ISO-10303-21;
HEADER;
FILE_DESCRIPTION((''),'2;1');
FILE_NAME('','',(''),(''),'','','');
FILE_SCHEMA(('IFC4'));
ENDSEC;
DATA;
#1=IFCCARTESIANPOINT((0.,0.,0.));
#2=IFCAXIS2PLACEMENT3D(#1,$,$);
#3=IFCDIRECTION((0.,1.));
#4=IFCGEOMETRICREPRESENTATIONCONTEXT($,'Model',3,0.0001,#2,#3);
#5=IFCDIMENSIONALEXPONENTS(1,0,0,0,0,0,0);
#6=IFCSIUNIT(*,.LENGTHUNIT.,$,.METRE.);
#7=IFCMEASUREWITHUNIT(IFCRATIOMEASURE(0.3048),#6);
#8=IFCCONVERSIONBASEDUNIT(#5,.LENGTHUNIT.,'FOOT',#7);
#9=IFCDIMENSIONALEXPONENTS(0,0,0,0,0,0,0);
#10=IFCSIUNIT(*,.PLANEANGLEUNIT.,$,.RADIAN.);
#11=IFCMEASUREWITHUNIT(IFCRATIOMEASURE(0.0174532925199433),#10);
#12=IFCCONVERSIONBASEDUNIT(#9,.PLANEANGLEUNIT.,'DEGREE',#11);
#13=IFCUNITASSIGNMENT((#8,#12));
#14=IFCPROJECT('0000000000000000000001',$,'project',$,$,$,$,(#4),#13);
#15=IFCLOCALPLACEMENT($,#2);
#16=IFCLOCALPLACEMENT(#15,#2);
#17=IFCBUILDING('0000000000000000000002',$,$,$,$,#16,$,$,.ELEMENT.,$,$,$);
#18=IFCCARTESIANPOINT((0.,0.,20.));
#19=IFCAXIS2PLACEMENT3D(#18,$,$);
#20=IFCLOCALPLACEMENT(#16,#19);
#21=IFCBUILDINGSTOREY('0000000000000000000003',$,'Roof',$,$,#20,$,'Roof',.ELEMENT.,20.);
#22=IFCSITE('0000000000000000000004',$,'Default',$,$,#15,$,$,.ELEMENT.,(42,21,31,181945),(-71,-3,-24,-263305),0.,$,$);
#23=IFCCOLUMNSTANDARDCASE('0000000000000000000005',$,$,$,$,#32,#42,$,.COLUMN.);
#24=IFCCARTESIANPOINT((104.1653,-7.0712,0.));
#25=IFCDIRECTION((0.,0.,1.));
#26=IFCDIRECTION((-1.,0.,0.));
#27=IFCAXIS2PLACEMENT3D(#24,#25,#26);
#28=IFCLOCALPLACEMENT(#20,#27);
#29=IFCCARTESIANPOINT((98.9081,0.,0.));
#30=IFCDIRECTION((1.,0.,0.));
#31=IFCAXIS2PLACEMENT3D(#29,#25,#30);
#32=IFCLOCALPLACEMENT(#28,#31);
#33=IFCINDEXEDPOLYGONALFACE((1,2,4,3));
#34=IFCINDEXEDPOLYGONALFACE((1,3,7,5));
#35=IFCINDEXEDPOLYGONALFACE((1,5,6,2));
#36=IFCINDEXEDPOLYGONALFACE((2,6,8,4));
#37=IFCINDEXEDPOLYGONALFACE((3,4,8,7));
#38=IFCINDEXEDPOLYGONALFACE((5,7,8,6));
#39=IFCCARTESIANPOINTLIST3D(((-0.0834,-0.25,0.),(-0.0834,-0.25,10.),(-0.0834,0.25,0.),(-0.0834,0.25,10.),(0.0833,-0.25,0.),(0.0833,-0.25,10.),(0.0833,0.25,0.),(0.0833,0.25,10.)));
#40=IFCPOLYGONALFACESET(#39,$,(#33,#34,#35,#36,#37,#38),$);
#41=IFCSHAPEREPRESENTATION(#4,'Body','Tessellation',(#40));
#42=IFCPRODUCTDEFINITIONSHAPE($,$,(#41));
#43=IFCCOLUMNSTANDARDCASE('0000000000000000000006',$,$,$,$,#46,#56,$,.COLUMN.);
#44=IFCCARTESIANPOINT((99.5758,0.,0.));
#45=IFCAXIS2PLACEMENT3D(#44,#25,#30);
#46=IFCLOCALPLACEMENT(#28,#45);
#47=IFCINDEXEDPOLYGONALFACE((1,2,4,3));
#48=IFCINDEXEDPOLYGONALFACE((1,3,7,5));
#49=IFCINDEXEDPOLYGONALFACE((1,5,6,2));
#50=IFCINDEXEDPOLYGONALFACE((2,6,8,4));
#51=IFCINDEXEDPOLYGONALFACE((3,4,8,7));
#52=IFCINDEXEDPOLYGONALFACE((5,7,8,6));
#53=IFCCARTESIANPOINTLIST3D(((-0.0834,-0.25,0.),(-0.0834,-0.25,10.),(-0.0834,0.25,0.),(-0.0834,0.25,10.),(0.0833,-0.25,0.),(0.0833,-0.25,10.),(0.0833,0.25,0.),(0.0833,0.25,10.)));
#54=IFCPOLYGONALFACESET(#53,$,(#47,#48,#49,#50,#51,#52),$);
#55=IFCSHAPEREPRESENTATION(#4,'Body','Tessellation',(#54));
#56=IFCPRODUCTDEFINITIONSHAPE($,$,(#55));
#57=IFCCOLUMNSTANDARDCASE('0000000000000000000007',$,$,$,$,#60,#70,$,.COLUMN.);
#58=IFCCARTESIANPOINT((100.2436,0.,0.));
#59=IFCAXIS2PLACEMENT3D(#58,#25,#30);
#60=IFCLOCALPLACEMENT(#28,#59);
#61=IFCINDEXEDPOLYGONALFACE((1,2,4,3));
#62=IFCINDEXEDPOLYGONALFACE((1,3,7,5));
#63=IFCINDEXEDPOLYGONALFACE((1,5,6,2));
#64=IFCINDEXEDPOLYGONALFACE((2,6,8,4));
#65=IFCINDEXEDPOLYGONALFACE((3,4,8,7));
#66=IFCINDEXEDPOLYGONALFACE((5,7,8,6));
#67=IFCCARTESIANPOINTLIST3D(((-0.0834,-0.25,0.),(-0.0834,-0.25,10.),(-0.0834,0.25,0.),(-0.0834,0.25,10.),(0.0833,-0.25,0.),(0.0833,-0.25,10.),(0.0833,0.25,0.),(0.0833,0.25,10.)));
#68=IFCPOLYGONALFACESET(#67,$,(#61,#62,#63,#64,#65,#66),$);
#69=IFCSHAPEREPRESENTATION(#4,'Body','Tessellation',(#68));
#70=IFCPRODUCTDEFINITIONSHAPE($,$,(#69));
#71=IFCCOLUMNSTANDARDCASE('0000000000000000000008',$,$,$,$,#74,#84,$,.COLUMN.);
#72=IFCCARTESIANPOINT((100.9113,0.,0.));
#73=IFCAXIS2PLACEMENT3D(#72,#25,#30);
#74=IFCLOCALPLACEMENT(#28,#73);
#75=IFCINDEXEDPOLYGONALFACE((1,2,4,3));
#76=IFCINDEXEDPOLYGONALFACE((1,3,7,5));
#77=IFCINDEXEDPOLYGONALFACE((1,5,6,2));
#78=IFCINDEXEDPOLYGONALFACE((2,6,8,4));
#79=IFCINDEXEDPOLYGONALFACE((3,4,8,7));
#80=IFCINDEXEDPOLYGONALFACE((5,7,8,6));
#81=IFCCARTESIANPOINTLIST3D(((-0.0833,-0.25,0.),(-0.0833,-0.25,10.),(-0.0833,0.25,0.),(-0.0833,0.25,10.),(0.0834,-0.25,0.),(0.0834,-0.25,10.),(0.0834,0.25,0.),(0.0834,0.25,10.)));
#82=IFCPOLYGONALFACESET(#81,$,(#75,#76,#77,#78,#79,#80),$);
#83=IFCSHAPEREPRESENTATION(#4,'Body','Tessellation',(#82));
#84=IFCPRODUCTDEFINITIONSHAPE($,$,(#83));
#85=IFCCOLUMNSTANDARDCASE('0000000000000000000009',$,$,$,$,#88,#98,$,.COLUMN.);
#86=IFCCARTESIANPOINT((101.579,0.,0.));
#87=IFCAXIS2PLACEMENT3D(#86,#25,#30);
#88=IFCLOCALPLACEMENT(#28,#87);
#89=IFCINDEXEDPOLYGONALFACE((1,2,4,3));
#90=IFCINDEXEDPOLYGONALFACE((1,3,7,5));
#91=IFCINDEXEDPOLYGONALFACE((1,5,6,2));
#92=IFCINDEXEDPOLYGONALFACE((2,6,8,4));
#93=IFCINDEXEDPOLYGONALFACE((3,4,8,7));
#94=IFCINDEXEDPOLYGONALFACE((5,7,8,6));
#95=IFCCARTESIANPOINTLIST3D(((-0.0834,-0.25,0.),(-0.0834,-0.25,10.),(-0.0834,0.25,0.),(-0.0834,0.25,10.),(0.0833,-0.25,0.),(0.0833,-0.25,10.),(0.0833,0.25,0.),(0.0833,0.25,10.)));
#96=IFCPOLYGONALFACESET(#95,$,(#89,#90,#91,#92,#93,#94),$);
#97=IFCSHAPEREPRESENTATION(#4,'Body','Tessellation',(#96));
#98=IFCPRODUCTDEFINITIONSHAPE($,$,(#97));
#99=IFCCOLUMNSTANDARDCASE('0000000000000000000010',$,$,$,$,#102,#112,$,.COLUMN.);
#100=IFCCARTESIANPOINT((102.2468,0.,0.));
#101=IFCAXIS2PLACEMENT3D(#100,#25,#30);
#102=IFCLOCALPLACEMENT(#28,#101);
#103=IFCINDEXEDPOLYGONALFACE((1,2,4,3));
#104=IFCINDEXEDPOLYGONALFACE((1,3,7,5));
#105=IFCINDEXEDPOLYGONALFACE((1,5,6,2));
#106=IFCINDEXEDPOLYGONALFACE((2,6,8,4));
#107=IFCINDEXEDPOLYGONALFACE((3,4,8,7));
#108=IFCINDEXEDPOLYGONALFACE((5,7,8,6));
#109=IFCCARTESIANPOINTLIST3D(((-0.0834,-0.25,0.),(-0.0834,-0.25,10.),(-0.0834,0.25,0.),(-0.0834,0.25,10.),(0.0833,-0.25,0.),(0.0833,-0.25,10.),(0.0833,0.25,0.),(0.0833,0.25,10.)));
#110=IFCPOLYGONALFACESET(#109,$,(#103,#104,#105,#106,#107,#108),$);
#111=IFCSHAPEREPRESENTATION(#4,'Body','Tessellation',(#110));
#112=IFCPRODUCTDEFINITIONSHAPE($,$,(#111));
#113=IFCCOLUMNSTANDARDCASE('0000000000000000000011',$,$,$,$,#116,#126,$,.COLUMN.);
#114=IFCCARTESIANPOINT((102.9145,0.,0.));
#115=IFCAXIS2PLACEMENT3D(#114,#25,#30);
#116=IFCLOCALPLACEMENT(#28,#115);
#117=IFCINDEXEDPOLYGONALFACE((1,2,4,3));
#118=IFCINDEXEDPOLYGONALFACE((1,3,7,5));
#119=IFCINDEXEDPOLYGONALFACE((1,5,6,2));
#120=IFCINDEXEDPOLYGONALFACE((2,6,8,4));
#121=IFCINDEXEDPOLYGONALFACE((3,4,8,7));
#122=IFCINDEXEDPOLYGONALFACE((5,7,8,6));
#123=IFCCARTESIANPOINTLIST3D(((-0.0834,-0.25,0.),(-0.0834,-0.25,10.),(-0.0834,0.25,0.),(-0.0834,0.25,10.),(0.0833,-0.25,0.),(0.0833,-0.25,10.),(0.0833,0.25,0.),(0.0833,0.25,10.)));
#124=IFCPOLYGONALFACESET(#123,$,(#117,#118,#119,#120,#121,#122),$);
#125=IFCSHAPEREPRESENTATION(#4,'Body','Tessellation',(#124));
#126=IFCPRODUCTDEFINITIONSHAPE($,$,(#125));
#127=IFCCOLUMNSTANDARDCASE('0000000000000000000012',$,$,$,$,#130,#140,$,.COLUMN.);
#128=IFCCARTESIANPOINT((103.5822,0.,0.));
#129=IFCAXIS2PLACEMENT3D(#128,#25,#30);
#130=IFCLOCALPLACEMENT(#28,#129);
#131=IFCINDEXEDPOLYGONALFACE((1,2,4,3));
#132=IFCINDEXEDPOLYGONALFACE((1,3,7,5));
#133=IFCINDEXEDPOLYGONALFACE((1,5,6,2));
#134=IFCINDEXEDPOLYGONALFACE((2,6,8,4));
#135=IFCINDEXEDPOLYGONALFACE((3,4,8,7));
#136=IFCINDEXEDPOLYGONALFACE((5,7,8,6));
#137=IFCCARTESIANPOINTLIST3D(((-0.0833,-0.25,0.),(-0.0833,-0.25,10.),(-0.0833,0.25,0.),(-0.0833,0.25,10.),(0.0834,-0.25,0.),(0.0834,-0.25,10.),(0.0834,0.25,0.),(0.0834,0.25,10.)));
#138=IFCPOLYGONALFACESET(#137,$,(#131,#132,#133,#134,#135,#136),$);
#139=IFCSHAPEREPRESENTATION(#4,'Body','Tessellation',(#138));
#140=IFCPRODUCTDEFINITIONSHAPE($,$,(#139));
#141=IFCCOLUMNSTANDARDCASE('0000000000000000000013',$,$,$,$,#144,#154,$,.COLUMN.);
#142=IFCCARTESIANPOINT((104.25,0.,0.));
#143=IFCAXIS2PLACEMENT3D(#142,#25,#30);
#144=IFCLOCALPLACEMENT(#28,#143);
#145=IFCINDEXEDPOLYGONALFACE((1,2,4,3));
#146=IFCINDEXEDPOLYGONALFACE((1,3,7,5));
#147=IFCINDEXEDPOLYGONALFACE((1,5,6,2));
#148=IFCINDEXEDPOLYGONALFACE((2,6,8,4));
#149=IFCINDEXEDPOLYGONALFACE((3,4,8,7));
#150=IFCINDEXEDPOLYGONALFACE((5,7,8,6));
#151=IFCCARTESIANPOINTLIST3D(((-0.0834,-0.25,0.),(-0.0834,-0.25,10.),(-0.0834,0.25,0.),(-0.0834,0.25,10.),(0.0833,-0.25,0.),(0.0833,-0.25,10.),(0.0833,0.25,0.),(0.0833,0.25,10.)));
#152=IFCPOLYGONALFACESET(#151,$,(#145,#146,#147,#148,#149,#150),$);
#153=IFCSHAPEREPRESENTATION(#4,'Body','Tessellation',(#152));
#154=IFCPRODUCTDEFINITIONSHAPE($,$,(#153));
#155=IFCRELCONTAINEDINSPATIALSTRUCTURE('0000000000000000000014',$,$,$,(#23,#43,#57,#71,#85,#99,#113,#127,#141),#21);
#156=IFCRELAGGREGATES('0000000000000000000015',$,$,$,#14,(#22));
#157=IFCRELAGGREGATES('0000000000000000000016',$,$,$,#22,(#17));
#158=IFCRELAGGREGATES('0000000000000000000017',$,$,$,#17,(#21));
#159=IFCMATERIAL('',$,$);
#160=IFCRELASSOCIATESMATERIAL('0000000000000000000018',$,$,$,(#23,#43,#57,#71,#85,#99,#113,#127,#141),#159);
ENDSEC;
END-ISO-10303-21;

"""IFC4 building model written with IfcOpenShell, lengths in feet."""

from ifc_helpers import new_model, entity, si_unit, converted_unit, direction, frame, origin, place, context, project, spatial, rectangle, extrude, material, element, save


model = new_model("IFC4")

# Units and contexts
model_context = context("Model", 3, precision=0.0001, world=origin(), true_north=direction((0.0, 1.0)))
ifc_project = project(units=[converted_unit("LENGTHUNIT", "FOOT", entity("IfcRatioMeasure", 0.3048), si_unit("LENGTHUNIT", "METRE"), dimensions=[1, 0, 0, 0, 0, 0, 0]), converted_unit("PLANEANGLEUNIT", "DEGREE", entity("IfcRatioMeasure", 0.0174532925199433), si_unit("PLANEANGLEUNIT", "RADIAN"), dimensions=[0, 0, 0, 0, 0, 0, 0])], contexts=[model_context])

# Site, building, storey
site_placement = place(None, origin())
site = spatial("IfcSite", under=ifc_project, at=site_placement, Name="Default", CompositionType="ELEMENT", RefLatitude=(42, 21, 31, 181945), RefLongitude=(-71, -3, -24, -263305), RefElevation=0.0)
building_placement = place(site_placement, origin())
building = spatial("IfcBuilding", under=site, at=building_placement, CompositionType="ELEMENT")
storey_placement = place(building_placement, frame((0.0, 0.0, 20.0)))
storey = spatial("IfcBuildingStorey", under=building, at=storey_placement, Name="Roof", LongName="Roof", CompositionType="ELEMENT", Elevation=20.0)

# Columns
ifc_material = material(Name="")
placement = place(storey_placement, frame((104.1653, -7.0712, 0.0), z_axis=(0.0, 0.0, 1.0), x_axis=(-1.0, 0.0, 0.0)))
for number, where, z_axis, x_axis in (
    (1, (98.9081, 0.0, 0.0), (0.0, 0.0, 1.0), (1.0, 0.0, 0.0)),
    (2, (99.5758, 0.0, 0.0), (0.0, 0.0, 1.0), (1.0, 0.0, 0.0)),
    (3, (100.2436, 0.0, 0.0), (0.0, 0.0, 1.0), (1.0, 0.0, 0.0)),
    (4, (100.9113, 0.0, 0.0), (0.0, 0.0, 1.0), (1.0, 0.0, 0.0)),
    (5, (101.579, 0.0, 0.0), (0.0, 0.0, 1.0), (1.0, 0.0, 0.0)),
    (6, (102.2468, 0.0, 0.0), (0.0, 0.0, 1.0), (1.0, 0.0, 0.0)),
    (7, (102.9145, 0.0, 0.0), (0.0, 0.0, 1.0), (1.0, 0.0, 0.0)),
    (8, (103.5822, 0.0, 0.0), (0.0, 0.0, 1.0), (1.0, 0.0, 0.0)),
    (9, (104.25, 0.0, 0.0), (0.0, 0.0, 1.0), (1.0, 0.0, 0.0)),
):
    element("IfcColumnStandardCase", number, at=place(placement, frame(where, z_axis=z_axis, x_axis=x_axis)), inside=storey, material=ifc_material, PredefinedType="COLUMN", context=model_context, shape_type="SweptSolid", body=[
        extrude(rectangle(XDim=0.1667, YDim=0.5), origin(), (0.0, 0.0, 1.0), 10.0),
    ])

save(model, "model.ifc")
